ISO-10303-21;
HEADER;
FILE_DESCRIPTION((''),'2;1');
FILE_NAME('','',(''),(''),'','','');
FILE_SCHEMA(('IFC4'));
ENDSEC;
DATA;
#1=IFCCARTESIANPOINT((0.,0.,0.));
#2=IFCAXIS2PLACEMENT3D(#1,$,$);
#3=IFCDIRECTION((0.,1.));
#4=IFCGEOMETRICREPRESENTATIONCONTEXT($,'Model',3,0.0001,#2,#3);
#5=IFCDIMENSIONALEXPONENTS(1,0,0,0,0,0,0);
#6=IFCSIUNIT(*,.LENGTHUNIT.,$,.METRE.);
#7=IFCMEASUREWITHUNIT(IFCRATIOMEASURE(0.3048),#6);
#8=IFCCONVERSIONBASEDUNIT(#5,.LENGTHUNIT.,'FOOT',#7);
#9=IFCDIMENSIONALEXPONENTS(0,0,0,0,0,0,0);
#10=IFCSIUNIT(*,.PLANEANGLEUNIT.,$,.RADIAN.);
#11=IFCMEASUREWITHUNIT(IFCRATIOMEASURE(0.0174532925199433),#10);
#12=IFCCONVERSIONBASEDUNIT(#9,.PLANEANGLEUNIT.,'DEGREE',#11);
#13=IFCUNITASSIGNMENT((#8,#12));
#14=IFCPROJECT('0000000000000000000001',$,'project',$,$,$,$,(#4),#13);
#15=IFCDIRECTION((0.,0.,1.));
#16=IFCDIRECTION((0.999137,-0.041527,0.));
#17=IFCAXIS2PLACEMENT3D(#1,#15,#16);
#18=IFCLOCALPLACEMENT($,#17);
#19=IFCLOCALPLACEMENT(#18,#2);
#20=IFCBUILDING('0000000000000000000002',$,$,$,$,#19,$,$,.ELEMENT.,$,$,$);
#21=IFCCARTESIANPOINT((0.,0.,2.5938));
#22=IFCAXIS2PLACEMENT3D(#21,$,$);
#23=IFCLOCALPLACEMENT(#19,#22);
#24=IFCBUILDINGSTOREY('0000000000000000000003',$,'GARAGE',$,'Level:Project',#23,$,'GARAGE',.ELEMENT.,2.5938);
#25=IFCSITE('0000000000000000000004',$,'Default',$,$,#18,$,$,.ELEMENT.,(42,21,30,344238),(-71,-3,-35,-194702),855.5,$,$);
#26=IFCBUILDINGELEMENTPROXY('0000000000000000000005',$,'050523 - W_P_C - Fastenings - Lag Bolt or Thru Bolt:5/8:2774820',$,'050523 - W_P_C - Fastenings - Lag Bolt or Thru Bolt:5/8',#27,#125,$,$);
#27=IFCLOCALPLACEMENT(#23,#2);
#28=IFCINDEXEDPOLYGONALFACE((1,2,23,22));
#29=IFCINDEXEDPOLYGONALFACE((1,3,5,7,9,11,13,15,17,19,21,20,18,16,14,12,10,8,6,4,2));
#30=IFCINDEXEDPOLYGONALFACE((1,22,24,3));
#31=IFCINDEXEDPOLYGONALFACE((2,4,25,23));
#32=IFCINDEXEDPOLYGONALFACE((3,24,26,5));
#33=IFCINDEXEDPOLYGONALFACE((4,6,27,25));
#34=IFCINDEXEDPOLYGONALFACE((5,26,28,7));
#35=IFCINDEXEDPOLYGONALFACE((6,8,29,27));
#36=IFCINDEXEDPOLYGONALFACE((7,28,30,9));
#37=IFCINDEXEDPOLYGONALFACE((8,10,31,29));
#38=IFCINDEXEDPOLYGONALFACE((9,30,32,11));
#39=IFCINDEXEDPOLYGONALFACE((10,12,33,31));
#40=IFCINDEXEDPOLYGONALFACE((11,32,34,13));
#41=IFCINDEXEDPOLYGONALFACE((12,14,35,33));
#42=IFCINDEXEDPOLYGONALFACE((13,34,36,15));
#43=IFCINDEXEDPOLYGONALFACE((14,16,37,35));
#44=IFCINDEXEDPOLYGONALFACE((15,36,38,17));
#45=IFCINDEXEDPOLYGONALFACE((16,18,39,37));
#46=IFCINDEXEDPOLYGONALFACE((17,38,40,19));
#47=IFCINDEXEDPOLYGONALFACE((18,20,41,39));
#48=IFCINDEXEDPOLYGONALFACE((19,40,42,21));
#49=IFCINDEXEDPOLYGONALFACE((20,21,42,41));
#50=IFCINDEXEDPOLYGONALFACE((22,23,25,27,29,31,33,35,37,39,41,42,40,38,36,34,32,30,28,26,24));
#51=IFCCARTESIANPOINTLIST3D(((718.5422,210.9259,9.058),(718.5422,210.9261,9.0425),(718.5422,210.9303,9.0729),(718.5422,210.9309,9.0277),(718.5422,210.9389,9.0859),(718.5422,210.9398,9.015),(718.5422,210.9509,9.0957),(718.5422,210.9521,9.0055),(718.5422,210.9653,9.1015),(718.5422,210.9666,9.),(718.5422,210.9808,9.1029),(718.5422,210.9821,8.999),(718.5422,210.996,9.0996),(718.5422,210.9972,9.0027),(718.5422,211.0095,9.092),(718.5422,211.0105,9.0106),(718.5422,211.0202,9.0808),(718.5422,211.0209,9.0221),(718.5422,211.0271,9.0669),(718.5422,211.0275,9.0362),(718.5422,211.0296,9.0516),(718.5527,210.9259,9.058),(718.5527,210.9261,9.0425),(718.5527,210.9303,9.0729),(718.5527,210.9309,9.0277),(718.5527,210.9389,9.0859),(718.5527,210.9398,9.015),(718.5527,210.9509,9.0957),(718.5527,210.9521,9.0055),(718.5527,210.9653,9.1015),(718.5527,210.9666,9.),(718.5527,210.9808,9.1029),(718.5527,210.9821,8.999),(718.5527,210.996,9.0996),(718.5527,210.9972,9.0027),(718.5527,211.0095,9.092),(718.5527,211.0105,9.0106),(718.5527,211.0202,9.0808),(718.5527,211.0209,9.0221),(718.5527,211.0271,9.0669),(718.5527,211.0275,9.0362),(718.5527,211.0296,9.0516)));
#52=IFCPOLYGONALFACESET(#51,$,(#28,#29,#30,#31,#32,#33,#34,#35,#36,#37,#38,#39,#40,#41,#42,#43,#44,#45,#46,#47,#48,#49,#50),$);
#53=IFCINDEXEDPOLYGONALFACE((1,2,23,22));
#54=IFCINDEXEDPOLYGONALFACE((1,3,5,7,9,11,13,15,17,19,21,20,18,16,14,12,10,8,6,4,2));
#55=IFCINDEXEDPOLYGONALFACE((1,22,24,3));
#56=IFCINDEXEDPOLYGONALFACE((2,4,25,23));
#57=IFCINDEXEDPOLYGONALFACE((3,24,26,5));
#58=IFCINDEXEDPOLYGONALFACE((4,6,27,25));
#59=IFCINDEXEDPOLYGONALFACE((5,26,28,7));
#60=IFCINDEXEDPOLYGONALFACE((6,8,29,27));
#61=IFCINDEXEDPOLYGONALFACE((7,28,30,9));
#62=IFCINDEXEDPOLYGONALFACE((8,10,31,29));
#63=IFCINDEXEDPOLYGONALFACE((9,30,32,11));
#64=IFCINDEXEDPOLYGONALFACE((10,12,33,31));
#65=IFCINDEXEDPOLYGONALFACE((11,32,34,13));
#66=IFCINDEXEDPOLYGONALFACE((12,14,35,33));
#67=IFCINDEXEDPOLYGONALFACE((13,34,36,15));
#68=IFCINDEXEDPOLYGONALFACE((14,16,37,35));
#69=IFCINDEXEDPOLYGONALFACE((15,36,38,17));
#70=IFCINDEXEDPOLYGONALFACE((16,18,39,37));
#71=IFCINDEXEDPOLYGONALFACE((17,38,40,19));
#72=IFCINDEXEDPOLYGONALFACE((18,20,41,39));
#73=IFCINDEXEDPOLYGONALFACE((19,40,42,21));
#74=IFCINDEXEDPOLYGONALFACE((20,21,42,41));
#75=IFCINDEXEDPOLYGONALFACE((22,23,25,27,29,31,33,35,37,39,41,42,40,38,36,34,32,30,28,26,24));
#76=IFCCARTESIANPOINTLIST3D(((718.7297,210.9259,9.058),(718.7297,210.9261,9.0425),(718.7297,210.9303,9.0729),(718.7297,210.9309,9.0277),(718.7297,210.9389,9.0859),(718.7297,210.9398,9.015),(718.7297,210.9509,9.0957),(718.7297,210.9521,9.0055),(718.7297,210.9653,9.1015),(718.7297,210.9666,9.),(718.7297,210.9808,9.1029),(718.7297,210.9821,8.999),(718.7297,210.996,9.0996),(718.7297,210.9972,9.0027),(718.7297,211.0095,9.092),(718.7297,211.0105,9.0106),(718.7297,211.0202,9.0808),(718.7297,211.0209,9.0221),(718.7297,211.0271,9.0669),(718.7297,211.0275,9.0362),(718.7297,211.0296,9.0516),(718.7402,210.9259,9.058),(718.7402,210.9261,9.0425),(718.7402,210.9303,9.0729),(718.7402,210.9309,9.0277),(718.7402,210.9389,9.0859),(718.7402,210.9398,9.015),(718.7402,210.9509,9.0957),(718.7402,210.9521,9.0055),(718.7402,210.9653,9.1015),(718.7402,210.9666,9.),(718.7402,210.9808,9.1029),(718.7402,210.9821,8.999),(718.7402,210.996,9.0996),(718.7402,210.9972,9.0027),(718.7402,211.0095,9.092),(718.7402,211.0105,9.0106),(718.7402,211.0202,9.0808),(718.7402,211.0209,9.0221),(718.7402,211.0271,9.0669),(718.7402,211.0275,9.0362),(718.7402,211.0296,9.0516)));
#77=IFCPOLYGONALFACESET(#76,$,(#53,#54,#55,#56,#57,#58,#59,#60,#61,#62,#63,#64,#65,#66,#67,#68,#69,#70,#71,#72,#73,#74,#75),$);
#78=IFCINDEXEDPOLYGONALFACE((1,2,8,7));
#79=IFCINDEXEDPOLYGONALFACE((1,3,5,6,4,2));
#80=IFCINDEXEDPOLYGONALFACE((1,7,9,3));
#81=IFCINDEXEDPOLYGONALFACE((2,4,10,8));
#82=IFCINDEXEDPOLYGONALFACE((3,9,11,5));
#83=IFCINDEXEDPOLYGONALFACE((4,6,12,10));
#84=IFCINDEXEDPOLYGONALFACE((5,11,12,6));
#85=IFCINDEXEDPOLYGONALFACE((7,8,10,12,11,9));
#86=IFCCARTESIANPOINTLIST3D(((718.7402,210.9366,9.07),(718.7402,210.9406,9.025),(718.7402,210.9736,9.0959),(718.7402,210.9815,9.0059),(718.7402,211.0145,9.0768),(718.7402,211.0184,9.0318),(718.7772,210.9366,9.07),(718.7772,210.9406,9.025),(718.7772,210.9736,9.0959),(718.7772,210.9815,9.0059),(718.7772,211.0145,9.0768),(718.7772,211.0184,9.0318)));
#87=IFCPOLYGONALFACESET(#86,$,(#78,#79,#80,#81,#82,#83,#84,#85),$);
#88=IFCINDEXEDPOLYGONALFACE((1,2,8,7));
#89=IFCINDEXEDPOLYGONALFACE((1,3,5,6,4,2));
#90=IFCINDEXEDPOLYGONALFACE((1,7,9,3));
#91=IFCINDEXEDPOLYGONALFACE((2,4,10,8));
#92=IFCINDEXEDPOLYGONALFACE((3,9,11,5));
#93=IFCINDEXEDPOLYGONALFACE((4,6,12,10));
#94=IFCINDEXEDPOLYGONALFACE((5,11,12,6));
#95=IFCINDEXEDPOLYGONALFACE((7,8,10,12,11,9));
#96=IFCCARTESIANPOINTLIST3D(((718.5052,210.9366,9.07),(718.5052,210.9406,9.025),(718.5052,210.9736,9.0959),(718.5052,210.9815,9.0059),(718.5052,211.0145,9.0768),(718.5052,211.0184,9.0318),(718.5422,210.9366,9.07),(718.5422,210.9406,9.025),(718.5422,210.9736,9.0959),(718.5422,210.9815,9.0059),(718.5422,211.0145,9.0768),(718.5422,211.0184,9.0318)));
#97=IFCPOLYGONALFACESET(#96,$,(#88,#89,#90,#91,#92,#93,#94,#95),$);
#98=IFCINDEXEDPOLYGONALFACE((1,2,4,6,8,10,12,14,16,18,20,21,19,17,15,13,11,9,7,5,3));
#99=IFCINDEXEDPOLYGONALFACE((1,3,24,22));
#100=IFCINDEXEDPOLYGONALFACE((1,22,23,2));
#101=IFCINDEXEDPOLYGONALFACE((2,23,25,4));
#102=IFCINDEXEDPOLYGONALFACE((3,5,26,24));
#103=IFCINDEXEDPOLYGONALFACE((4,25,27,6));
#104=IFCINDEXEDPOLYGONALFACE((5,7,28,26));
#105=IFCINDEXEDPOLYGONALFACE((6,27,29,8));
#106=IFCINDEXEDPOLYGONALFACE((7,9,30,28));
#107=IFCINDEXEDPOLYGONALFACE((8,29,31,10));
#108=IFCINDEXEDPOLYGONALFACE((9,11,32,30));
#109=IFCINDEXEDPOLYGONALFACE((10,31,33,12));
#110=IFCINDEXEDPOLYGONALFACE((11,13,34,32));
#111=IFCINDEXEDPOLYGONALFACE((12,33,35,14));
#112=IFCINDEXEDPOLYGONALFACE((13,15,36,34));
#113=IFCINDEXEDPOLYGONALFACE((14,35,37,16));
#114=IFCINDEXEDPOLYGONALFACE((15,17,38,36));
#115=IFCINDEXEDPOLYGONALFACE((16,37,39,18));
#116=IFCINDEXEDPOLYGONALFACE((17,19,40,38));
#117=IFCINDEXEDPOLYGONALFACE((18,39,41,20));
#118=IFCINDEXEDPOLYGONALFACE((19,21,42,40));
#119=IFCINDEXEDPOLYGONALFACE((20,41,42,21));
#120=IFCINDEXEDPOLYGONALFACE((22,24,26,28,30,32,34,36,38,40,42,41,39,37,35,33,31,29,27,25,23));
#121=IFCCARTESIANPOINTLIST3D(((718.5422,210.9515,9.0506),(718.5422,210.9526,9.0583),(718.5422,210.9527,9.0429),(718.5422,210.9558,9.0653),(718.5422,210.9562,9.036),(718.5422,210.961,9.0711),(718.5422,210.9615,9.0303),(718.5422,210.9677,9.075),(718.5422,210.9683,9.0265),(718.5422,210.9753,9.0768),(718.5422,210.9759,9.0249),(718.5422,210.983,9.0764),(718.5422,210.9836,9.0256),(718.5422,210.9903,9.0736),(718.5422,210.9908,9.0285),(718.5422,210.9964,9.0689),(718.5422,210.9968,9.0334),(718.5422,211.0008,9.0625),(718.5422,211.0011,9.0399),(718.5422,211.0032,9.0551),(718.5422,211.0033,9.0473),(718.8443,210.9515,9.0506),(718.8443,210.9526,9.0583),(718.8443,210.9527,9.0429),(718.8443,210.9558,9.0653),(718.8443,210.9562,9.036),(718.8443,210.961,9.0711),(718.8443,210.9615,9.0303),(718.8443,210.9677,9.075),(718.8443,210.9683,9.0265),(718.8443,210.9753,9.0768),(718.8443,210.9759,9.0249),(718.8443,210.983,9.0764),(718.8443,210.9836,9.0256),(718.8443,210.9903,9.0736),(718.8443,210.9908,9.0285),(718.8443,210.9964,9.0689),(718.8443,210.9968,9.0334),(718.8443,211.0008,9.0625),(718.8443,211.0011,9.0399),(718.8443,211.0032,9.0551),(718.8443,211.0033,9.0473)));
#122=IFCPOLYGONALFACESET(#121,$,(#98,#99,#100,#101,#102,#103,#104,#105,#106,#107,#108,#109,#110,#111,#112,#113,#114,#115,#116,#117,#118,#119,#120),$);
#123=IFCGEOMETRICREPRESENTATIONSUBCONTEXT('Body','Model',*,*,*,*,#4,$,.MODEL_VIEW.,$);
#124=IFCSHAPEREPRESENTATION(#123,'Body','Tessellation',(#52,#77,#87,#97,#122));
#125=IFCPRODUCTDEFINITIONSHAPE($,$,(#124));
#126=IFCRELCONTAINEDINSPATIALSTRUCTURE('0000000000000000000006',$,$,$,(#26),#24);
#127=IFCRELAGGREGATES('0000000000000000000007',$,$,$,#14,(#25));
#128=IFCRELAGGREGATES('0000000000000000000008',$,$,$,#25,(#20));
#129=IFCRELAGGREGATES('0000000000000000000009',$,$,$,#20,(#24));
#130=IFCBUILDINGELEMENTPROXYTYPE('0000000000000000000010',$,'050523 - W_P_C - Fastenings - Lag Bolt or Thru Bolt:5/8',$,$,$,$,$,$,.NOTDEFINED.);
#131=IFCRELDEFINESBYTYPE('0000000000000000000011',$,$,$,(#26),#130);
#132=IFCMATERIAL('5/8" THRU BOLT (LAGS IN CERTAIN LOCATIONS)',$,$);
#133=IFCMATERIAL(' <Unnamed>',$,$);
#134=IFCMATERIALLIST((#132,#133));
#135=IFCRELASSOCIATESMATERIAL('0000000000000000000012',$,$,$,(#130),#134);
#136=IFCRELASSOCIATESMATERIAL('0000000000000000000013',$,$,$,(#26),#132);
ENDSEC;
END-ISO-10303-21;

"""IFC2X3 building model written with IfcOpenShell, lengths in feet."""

from ifc_helpers import new_model, entity, si_unit, converted_unit, direction, frame, frame_2d, origin, place, context, subcontext, project, spatial, polyline, circle, outline, extrude, source, transform, mapped, material, material_list, type_object, type_shapes, element, save


model = new_model("IFC2X3")

# Units and contexts
model_context = context("Model", 3, precision=0.0001, world=origin(), true_north=direction((0.0, 1.0)))
body_context = subcontext(model_context, "Body", "Model", "MODEL_VIEW")
ifc_project = project(units=[converted_unit("LENGTHUNIT", "FOOT", entity("IfcRatioMeasure", 0.3048), si_unit("LENGTHUNIT", "METRE"), dimensions=[1, 0, 0, 0, 0, 0, 0]), converted_unit("PLANEANGLEUNIT", "DEGREE", entity("IfcRatioMeasure", 0.0174532925199433), si_unit("PLANEANGLEUNIT", "RADIAN"), dimensions=[0, 0, 0, 0, 0, 0, 0])], contexts=[model_context])

# Site, building, storey
site_placement = place(None, frame((0.0, 0.0, 0.0), z_axis=(0.0, 0.0, 1.0), x_axis=(0.999137, -0.041527, 0.0)))
site = spatial("IfcSite", under=ifc_project, at=site_placement, Name="Default", CompositionType="ELEMENT", RefLatitude=(42, 21, 30, 344238), RefLongitude=(-71, -3, -35, -194702), RefElevation=855.5)
building_placement = place(site_placement, origin())
building = spatial("IfcBuilding", under=site, at=building_placement, CompositionType="ELEMENT")
storey_placement = place(building_placement, frame((0.0, 0.0, 2.5938)))
storey = spatial("IfcBuildingStorey", under=building, at=storey_placement, Name="GARAGE", ObjectType="Level:Project", LongName="GARAGE", CompositionType="ELEMENT", Elevation=2.5938)

# Building element proxy
ifc_material_1 = material(Name="5/8\" THRU BOLT (LAGS IN CERTAIN LOCATIONS)")
ifc_material_2 = material(Name=" <Unnamed>")
ifc_material_list_1 = material_list([ifc_material_1, ifc_material_2])
building_element_proxy_type_1 = type_object("IfcBuildingElementProxyType", Name="050523 - W_P_C - Fastenings - Lag Bolt or Thru Bolt:5/8", PredefinedType="NOTDEFINED", material=ifc_material_list_1)
shared_shape_1 = source(origin(), body_context, "Body", "SweptSolid", [
    extrude(circle(Radius=0.0521, at=frame_2d((0.0, 0.0), x_axis=(1.0, 0.0))), frame((0.0, 0.0, 0.0), z_axis=(0.0, 0.0, 1.0), x_axis=(0.0, -1.0, 0.0)), (0.0, 0.0, 1.0), 0.0104),
    extrude(circle(Radius=0.0521, at=frame_2d((0.0, 0.0), x_axis=(1.0, 0.0))), frame((0.0, 0.0, -0.1875), z_axis=(0.0, 0.0, 1.0), x_axis=(0.0, -1.0, 0.0)), (0.0, 0.0, 1.0), 0.0104),
    extrude(outline(polyline([(-0.0226, -0.0391), (0.0226, -0.0391), (0.0451, 0.0), (0.0226, 0.0391), (-0.0226, 0.0391), (-0.0451, 0.0), (-0.0226, -0.0391)])), frame((0.0, 0.0, -0.2245), z_axis=(0.0, 0.0, 1.0), x_axis=(0.866025, -0.5, 0.0)), (0.0, 0.0, 1.0), 0.037),
    extrude(outline(polyline([(-0.0226, -0.0391), (0.0226, -0.0391), (0.0451, 0.0), (0.0226, 0.0391), (-0.0226, 0.0391), (-0.0451, 0.0), (-0.0226, -0.0391)])), frame((0.0, 0.0, 0.0104), z_axis=(0.0, 0.0, 1.0), x_axis=(0.0, -1.0, 0.0)), (0.0, 0.0, 1.0), 0.037),
    extrude(circle(Radius=0.026, at=frame_2d((0.0, 0.0), x_axis=(1.0, 0.0))), frame((0.0, 0.0, -0.2917), z_axis=(0.0, 0.0, 1.0), x_axis=(0.0, 1.0, 0.0)), (0.0, 0.0, 1.0), 0.3021),
])
type_shapes(building_element_proxy_type_1, [shared_shape_1])
for number, where, z_axis, x_axis, name in (
    (1, (718.5527, 210.9775, 9.0509), (-1.0, 0.0, 0.0), (0.0, -0.996195, -0.087156), "050523 - W_P_C - Fastenings - Lag Bolt or Thru Bolt:5/8:2774820"),
):
    element("IfcBuildingElementProxy", number, at=place(storey_placement, frame(where, z_axis=z_axis, x_axis=x_axis)), inside=storey, type_object=building_element_proxy_type_1, material=ifc_material_1, Name=name, ObjectType="050523 - W_P_C - Fastenings - Lag Bolt or Thru Bolt:5/8", context=body_context, shape_type="MappedRepresentation", body=[
        mapped(shared_shape_1, transform((0.0, 0.0, 0.0), scale=1.0)),
    ])

save(model, "model.ifc")
